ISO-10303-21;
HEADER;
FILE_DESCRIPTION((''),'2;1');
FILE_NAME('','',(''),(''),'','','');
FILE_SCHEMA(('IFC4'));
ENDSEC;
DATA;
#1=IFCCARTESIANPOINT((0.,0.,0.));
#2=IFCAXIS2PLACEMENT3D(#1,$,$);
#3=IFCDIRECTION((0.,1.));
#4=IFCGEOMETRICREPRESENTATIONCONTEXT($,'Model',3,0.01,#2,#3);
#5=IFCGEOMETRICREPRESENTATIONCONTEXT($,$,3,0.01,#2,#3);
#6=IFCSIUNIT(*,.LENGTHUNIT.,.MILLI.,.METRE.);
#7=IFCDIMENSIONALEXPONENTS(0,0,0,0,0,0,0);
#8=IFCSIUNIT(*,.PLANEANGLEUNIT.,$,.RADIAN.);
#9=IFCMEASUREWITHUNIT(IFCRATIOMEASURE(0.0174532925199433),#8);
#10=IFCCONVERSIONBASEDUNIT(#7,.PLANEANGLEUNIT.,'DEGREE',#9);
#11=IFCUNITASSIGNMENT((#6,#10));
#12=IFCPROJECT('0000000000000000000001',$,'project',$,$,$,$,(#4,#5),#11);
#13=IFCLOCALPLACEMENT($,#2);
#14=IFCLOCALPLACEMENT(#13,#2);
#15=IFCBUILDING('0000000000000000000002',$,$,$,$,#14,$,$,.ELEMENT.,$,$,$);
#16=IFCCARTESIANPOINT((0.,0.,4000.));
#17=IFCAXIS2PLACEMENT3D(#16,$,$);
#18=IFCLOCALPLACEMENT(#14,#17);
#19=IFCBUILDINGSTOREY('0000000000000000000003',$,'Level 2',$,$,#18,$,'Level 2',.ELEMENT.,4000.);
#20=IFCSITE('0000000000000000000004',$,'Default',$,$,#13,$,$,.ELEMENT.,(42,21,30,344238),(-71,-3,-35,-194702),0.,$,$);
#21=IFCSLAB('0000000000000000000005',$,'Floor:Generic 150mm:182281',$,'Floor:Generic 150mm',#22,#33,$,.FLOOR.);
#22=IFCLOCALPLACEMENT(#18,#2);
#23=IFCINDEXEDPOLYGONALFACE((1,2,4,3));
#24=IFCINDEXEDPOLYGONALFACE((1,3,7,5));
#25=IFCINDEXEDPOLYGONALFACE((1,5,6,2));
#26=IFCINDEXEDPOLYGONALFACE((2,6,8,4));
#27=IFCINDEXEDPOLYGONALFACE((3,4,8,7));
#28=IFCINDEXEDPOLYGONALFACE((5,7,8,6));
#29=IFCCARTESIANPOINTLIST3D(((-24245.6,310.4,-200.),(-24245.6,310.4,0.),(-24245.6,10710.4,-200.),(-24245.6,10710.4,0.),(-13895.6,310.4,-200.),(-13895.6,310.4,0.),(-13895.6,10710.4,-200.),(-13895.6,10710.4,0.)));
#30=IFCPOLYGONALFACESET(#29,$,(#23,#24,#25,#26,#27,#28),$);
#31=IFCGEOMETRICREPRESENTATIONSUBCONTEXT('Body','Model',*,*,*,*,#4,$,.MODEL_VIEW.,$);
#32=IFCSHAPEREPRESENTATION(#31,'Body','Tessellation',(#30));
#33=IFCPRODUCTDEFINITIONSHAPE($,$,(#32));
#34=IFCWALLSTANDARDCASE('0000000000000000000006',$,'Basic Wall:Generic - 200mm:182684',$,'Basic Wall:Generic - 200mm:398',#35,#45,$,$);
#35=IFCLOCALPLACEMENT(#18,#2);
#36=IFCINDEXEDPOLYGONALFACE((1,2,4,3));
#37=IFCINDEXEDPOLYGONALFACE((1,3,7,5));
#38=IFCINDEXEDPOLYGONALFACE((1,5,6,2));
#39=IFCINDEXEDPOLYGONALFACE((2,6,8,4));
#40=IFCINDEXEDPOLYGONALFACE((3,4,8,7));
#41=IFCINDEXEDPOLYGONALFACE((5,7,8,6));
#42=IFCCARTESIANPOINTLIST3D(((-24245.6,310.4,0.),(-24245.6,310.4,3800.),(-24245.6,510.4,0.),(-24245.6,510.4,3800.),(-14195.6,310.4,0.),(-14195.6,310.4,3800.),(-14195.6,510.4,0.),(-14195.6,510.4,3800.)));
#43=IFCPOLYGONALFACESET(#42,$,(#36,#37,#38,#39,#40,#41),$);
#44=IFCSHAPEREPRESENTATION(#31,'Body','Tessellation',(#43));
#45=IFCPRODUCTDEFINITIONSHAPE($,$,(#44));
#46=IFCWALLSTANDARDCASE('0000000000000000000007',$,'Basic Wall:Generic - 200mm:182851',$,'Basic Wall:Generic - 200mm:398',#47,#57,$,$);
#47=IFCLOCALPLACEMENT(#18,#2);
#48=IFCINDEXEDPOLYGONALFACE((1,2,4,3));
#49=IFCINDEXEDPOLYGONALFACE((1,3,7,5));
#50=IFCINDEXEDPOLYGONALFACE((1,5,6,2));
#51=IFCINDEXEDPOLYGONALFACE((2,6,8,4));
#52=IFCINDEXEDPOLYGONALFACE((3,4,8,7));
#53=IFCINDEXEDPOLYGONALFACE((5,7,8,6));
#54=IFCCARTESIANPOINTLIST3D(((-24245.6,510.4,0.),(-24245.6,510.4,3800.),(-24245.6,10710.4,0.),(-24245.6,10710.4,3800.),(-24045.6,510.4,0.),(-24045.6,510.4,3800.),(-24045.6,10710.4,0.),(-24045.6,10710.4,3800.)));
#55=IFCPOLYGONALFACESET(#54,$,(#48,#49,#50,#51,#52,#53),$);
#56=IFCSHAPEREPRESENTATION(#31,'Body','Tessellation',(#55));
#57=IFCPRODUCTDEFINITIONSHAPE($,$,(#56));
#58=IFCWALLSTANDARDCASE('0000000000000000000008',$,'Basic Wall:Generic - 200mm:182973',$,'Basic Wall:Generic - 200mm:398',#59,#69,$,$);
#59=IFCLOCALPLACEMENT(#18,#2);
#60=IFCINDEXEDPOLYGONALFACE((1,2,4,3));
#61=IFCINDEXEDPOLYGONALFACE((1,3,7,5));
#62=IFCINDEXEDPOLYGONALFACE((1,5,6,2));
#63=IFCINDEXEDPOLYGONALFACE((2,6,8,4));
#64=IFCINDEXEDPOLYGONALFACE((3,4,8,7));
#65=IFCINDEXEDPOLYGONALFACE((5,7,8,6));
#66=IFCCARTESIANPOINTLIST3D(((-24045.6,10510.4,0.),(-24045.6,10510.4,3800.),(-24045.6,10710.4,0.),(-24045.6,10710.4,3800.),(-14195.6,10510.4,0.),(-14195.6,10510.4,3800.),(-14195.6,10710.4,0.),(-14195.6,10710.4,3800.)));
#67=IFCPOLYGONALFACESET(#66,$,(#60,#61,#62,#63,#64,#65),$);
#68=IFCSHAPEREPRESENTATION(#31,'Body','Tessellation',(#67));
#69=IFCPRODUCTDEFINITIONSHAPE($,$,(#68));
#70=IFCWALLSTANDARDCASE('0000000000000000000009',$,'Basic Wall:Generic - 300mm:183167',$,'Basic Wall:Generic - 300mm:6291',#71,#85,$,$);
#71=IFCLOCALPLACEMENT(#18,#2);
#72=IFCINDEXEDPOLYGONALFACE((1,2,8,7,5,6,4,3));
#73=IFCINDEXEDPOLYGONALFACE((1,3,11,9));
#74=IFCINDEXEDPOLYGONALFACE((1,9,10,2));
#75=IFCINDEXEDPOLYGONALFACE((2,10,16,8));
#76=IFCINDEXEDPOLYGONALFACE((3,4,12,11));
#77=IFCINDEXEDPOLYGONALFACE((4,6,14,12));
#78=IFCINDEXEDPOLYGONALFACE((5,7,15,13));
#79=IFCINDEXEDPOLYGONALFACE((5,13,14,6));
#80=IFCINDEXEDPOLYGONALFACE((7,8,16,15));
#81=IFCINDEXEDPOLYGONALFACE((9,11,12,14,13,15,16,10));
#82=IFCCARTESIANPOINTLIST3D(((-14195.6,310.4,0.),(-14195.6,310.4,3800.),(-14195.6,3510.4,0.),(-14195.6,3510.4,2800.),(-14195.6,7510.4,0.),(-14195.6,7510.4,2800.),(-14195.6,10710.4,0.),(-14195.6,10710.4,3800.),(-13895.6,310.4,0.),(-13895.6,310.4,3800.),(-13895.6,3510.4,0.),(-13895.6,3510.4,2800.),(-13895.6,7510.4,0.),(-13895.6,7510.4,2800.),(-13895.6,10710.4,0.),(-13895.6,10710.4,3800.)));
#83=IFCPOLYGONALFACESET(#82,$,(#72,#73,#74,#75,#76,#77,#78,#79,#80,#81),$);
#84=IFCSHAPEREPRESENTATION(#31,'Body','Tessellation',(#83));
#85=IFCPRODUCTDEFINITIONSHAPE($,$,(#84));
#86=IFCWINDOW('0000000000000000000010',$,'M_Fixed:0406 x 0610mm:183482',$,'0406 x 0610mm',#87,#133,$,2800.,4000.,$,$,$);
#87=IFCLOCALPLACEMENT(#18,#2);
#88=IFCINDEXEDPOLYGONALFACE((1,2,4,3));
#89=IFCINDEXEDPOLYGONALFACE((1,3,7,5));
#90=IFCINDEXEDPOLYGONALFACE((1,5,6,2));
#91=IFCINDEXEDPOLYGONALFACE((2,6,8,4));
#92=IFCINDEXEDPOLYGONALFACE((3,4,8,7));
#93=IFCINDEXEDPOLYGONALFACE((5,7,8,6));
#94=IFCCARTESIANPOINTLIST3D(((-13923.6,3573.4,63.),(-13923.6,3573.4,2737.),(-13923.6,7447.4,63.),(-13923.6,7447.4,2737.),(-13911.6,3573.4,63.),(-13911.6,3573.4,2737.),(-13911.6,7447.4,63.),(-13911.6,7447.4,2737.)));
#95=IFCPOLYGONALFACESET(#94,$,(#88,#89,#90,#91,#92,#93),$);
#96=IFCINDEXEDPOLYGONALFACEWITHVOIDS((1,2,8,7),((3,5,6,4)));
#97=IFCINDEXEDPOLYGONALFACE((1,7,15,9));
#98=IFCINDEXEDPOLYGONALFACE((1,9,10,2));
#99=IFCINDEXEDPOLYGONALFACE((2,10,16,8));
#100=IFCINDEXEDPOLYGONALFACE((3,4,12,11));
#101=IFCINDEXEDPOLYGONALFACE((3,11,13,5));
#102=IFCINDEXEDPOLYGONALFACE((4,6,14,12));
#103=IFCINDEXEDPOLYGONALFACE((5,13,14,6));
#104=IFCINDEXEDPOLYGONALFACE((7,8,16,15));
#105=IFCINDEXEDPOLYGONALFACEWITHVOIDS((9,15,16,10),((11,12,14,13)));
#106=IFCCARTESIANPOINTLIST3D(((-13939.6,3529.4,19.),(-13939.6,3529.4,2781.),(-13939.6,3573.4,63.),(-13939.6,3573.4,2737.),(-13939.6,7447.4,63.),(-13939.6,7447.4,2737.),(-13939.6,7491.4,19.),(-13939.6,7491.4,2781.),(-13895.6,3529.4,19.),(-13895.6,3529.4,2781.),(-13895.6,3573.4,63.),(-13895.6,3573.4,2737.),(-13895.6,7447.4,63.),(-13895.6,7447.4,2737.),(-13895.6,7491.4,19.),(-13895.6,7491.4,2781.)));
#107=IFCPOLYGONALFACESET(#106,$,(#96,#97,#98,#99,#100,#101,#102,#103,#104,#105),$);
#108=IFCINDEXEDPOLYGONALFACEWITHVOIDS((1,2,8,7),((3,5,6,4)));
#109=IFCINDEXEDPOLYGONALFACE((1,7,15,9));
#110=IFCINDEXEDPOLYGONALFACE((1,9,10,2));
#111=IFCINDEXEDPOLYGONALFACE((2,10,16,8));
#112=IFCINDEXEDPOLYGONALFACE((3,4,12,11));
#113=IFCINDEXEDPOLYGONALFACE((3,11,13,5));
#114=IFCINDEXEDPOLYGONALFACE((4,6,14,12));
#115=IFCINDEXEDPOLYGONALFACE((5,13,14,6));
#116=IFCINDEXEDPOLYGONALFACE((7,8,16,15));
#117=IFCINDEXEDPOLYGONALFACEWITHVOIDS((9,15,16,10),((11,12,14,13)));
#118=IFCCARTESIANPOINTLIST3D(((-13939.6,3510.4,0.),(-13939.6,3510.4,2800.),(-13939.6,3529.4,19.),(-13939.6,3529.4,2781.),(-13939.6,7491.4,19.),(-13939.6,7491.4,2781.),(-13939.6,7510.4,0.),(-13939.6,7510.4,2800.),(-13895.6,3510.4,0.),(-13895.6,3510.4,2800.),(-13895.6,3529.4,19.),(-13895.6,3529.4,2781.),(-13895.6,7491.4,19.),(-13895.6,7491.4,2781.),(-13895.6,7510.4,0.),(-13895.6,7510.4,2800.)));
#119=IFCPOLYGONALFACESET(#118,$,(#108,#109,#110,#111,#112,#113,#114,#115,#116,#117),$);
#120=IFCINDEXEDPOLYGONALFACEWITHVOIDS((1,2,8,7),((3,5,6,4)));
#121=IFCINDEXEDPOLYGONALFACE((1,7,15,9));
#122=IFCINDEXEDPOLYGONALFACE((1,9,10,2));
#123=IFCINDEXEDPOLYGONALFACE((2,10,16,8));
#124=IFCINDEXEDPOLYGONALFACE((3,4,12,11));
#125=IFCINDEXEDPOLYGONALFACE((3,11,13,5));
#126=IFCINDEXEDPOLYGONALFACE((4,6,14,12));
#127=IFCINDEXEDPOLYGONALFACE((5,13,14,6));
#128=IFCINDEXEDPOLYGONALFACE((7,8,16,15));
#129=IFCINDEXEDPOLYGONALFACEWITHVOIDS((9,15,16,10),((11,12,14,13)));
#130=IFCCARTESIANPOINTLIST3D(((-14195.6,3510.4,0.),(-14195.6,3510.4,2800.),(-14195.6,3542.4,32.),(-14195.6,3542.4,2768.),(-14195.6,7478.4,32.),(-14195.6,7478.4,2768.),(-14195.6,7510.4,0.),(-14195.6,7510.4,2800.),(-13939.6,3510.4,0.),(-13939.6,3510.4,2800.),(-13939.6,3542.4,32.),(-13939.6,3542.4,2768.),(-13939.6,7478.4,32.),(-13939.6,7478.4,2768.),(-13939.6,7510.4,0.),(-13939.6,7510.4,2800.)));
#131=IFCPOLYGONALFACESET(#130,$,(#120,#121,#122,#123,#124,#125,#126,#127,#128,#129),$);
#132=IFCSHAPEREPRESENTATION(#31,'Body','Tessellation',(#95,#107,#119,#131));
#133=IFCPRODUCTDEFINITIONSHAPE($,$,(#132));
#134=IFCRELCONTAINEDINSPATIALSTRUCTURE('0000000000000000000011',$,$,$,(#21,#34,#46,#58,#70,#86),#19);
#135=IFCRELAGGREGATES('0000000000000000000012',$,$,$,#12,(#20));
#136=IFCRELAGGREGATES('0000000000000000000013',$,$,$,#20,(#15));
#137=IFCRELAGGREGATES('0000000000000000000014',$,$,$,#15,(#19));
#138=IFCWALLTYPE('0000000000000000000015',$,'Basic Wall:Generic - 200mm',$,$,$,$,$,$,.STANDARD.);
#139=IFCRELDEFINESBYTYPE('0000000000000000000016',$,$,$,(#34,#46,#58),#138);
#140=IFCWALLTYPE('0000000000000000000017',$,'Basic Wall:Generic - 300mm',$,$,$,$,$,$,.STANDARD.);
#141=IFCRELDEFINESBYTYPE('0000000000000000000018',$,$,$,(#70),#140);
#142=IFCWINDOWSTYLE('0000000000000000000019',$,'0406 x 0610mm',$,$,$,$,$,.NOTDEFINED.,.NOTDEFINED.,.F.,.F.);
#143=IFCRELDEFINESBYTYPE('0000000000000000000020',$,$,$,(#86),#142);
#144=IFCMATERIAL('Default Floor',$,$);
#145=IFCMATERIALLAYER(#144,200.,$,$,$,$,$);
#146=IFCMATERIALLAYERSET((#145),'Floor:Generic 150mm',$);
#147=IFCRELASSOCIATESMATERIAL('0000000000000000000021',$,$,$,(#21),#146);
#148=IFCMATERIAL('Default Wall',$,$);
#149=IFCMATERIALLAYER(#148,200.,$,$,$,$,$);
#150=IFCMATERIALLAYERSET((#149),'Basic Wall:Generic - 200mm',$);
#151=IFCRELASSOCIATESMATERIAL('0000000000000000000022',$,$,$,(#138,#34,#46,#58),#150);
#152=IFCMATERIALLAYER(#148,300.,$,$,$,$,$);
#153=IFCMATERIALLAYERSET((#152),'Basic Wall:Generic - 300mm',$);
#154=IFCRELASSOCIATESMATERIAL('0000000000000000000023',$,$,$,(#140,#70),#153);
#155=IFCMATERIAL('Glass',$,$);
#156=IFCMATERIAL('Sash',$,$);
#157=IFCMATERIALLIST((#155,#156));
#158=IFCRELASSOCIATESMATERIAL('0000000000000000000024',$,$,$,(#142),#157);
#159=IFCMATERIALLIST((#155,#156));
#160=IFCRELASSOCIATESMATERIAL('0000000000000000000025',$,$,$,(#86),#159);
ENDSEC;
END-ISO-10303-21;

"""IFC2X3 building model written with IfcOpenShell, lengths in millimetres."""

from ifc_helpers import new_model, entity, si_unit, converted_unit, direction, frame, frame_2d, origin, place, context, subcontext, project, spatial, polyline, rectangle, outline, extrude, source, transform, mapped, material, material_list, layer, layer_set, layer_usage, type_object, type_shapes, element, fill, save


model = new_model("IFC2X3")

# Units and contexts
model_context = context("Model", 3, precision=0.01, world=origin(), true_north=direction((0.0, 1.0)))
context_of_model = context(None, 3, precision=0.01, world=origin(), true_north=direction((0.0, 1.0)))
body_context = subcontext(model_context, "Body", "Model", "MODEL_VIEW")
ifc_project = project(units=[si_unit("LENGTHUNIT", "METRE", prefix="MILLI"), converted_unit("PLANEANGLEUNIT", "DEGREE", entity("IfcRatioMeasure", 0.0174532925199433), si_unit("PLANEANGLEUNIT", "RADIAN"), dimensions=[0, 0, 0, 0, 0, 0, 0])], contexts=[model_context, context_of_model])

# Site, building, storey
site_placement = place(None, origin())
site = spatial("IfcSite", under=ifc_project, at=site_placement, Name="Default", CompositionType="ELEMENT", RefLatitude=(42, 21, 30, 344238), RefLongitude=(-71, -3, -35, -194702), RefElevation=0.0)
building_placement = place(site_placement, origin())
building = spatial("IfcBuilding", under=site, at=building_placement, CompositionType="ELEMENT")
storey_placement = place(building_placement, frame((0.0, 0.0, 4000.0)))
storey = spatial("IfcBuildingStorey", under=building, at=storey_placement, Name="Level 2", LongName="Level 2", CompositionType="ELEMENT", Elevation=4000.0)

# Slab
ifc_material_1 = material(Name="Default Floor")
ifc_layer_1 = layer(ifc_material_1, 200.0)
ifc_layer_set_1 = layer_set([ifc_layer_1], Name="Floor:Generic 150mm")
ifc_layer_usage_1 = layer_usage(ifc_layer_set_1, "AXIS3", "POSITIVE", 0.0)
slab_placement = place(storey_placement, origin())
element("IfcSlab", 1, at=slab_placement, inside=storey, material=ifc_layer_usage_1, Name="Floor:Generic 150mm:182281", ObjectType="Floor:Generic 150mm", PredefinedType="FLOOR", context=body_context, shape_type="SweptSolid", body=[
    extrude(rectangle(XDim=10400.0, YDim=10350.0, at=frame_2d((0.0, 0.0), x_axis=(1.0, 0.0))), frame((-19070.6, 5510.4, 0.0), z_axis=(0.0, 0.0, -1.0), x_axis=(0.0, 1.0, 0.0)), (0.0, 0.0, 1.0), 200.0),
])

# Walls
ifc_material_2 = material(Name="Default Wall")
ifc_layer_2 = layer(ifc_material_2, 200.0)
ifc_layer_set_2 = layer_set([ifc_layer_2], Name="Basic Wall:Generic - 200mm")
ifc_layer_usage_2 = layer_usage(ifc_layer_set_2, "AXIS2", "NEGATIVE", 100.0)
wall_type_1 = type_object("IfcWallType", Name="Basic Wall:Generic - 200mm", PredefinedType="STANDARD", material=ifc_layer_set_2)
wall_1_placement = place(storey_placement, frame((-14195.6, 410.4, 0.0), z_axis=(0.0, 0.0, 1.0), x_axis=(-1.0, 0.0, 0.0)))
element("IfcWallStandardCase", 2, at=wall_1_placement, inside=storey, type_object=wall_type_1, material=ifc_layer_usage_2, Name="Basic Wall:Generic - 200mm:182684", ObjectType="Basic Wall:Generic - 200mm:398", context=body_context, shape_type="SweptSolid", body=[
    extrude(rectangle(XDim=10050.0, YDim=200.0, at=frame_2d((5025.0, 0.0), x_axis=(-1.0, 0.0))), origin(), (0.0, 0.0, 1.0), 3800.0),
])
ifc_layer_usage_3 = layer_usage(ifc_layer_set_2, "AXIS2", "NEGATIVE", 100.0)
wall_2_placement = place(storey_placement, frame((-24145.6, 510.4, 0.0), z_axis=(0.0, 0.0, 1.0), x_axis=(0.0, 1.0, 0.0)))
element("IfcWallStandardCase", 3, at=wall_2_placement, inside=storey, type_object=wall_type_1, material=ifc_layer_usage_3, Name="Basic Wall:Generic - 200mm:182851", ObjectType="Basic Wall:Generic - 200mm:398", context=body_context, shape_type="SweptSolid", body=[
    extrude(rectangle(XDim=10200.0, YDim=200.0, at=frame_2d((5100.0, 0.0), x_axis=(-1.0, 0.0))), origin(), (0.0, 0.0, 1.0), 3800.0),
])
ifc_layer_usage_4 = layer_usage(ifc_layer_set_2, "AXIS2", "NEGATIVE", 100.0)
wall_3_placement = place(storey_placement, frame((-24045.6, 10610.4, 0.0)))
element("IfcWallStandardCase", 4, at=wall_3_placement, inside=storey, type_object=wall_type_1, material=ifc_layer_usage_4, Name="Basic Wall:Generic - 200mm:182973", ObjectType="Basic Wall:Generic - 200mm:398", context=body_context, shape_type="SweptSolid", body=[
    extrude(rectangle(XDim=9850.0, YDim=200.0, at=frame_2d((4925.0, 0.0), x_axis=(-1.0, 0.0))), origin(), (0.0, 0.0, 1.0), 3800.0),
])

# Wall, opening, window
ifc_layer_3 = layer(ifc_material_2, 300.0)
ifc_layer_set_3 = layer_set([ifc_layer_3], Name="Basic Wall:Generic - 300mm")
ifc_layer_usage_5 = layer_usage(ifc_layer_set_3, "AXIS2", "NEGATIVE", 150.0)
wall_type_2 = type_object("IfcWallType", Name="Basic Wall:Generic - 300mm", PredefinedType="STANDARD", material=ifc_layer_set_3)
wall_4_placement = place(storey_placement, frame((-14045.6, 10710.4, 0.0), z_axis=(0.0, 0.0, 1.0), x_axis=(0.0, -1.0, 0.0)))
wall_4 = element("IfcWallStandardCase", 5, at=wall_4_placement, inside=storey, type_object=wall_type_2, material=ifc_layer_usage_5, Name="Basic Wall:Generic - 300mm:183167", ObjectType="Basic Wall:Generic - 300mm:6291", context=body_context, shape_type="SweptSolid", body=[
    extrude(rectangle(XDim=10400.0, YDim=300.0, at=frame_2d((5200.0, 0.0), x_axis=(-1.0, 0.0))), origin(), (0.0, 0.0, 1.0), 3800.0),
])
opening_placement = place(wall_4_placement, frame((3200.0, -150.0, 0.0)))
opening = element("IfcOpeningElement", 6, at=opening_placement, cuts=wall_4, ObjectType="Opening", context=body_context, shape_type="SweptSolid", body=[
    extrude(rectangle(XDim=2800.0, YDim=4000.0, at=frame_2d((1400.0, 2000.0), x_axis=(1.0, 0.0))), frame((0.0, 0.0, 0.0), z_axis=(0.0, 1.0, 0.0), x_axis=(0.0, 0.0, 1.0)), (0.0, 0.0, 1.0), 300.0),
])
ifc_material_3 = material(Name="Glass")
ifc_material_4 = material(Name="Sash")
ifc_material_list_1 = material_list([ifc_material_3, ifc_material_4])
ifc_material_list_2 = material_list([ifc_material_3, ifc_material_4])
window_style = type_object("IfcWindowStyle", Name="0406 x 0610mm", ConstructionType="NOTDEFINED", OperationType="NOTDEFINED", ParameterTakesPrecedence=False, Sizeable=False, material=ifc_material_list_2)
shared_shape = source(origin(), body_context, "Body", "SweptSolid", [
    extrude(rectangle(XDim=12.0, YDim=3874.0, at=frame_2d((0.0, 0.0), x_axis=(1.0, 0.0))), frame((2000.0, 278.0, 63.0), z_axis=(0.0, 0.0, 1.0), x_axis=(0.0, -1.0, 0.0)), (0.0, 0.0, 1.0), 2674.0),
    extrude(outline(polyline([(-1981.0, -1381.0), (1981.0, -1381.0), (1981.0, 1381.0), (-1981.0, 1381.0), (-1981.0, -1381.0)]), holes=[polyline([(-1937.0, -1337.0), (-1937.0, 1337.0), (1937.0, 1337.0), (1937.0, -1337.0), (-1937.0, -1337.0)])]), frame((2000.0, 256.0, 1400.0), z_axis=(0.0, 1.0, 0.0), x_axis=(1.0, 0.0, 0.0)), (0.0, 0.0, 1.0), 44.0),
    extrude(outline(polyline([(-2000.0, -1400.0), (2000.0, -1400.0), (2000.0, 1400.0), (-2000.0, 1400.0), (-2000.0, -1400.0)]), holes=[polyline([(-1981.0, -1381.0), (-1981.0, 1381.0), (1981.0, 1381.0), (1981.0, -1381.0), (-1981.0, -1381.0)])]), frame((2000.0, 256.0, 1400.0), z_axis=(0.0, 1.0, 0.0), x_axis=(1.0, 0.0, 0.0)), (0.0, 0.0, 1.0), 44.0),
    extrude(outline(polyline([(-2000.0, -1400.0), (2000.0, -1400.0), (2000.0, 1400.0), (-2000.0, 1400.0), (-2000.0, -1400.0)]), holes=[polyline([(-1968.0, -1368.0), (-1968.0, 1368.0), (1968.0, 1368.0), (1968.0, -1368.0), (-1968.0, -1368.0)])]), frame((2000.0, 0.0, 1400.0), z_axis=(0.0, 1.0, 0.0), x_axis=(1.0, 0.0, 0.0)), (0.0, 0.0, 1.0), 256.0),
])
type_shapes(window_style, [shared_shape])
window_placement = place(opening_placement, origin())
window = element("IfcWindow", 7, at=window_placement, inside=storey, type_object=window_style, material=ifc_material_list_1, Name="M_Fixed:0406 x 0610mm:183482", ObjectType="0406 x 0610mm", OverallHeight=2800.0, OverallWidth=4000.0, context=body_context, shape_type="MappedRepresentation", body=[
    mapped(shared_shape, transform((0.0, 0.0, 0.0), scale=1.0)),
])
fill(opening, window)

save(model, "model.ifc")
